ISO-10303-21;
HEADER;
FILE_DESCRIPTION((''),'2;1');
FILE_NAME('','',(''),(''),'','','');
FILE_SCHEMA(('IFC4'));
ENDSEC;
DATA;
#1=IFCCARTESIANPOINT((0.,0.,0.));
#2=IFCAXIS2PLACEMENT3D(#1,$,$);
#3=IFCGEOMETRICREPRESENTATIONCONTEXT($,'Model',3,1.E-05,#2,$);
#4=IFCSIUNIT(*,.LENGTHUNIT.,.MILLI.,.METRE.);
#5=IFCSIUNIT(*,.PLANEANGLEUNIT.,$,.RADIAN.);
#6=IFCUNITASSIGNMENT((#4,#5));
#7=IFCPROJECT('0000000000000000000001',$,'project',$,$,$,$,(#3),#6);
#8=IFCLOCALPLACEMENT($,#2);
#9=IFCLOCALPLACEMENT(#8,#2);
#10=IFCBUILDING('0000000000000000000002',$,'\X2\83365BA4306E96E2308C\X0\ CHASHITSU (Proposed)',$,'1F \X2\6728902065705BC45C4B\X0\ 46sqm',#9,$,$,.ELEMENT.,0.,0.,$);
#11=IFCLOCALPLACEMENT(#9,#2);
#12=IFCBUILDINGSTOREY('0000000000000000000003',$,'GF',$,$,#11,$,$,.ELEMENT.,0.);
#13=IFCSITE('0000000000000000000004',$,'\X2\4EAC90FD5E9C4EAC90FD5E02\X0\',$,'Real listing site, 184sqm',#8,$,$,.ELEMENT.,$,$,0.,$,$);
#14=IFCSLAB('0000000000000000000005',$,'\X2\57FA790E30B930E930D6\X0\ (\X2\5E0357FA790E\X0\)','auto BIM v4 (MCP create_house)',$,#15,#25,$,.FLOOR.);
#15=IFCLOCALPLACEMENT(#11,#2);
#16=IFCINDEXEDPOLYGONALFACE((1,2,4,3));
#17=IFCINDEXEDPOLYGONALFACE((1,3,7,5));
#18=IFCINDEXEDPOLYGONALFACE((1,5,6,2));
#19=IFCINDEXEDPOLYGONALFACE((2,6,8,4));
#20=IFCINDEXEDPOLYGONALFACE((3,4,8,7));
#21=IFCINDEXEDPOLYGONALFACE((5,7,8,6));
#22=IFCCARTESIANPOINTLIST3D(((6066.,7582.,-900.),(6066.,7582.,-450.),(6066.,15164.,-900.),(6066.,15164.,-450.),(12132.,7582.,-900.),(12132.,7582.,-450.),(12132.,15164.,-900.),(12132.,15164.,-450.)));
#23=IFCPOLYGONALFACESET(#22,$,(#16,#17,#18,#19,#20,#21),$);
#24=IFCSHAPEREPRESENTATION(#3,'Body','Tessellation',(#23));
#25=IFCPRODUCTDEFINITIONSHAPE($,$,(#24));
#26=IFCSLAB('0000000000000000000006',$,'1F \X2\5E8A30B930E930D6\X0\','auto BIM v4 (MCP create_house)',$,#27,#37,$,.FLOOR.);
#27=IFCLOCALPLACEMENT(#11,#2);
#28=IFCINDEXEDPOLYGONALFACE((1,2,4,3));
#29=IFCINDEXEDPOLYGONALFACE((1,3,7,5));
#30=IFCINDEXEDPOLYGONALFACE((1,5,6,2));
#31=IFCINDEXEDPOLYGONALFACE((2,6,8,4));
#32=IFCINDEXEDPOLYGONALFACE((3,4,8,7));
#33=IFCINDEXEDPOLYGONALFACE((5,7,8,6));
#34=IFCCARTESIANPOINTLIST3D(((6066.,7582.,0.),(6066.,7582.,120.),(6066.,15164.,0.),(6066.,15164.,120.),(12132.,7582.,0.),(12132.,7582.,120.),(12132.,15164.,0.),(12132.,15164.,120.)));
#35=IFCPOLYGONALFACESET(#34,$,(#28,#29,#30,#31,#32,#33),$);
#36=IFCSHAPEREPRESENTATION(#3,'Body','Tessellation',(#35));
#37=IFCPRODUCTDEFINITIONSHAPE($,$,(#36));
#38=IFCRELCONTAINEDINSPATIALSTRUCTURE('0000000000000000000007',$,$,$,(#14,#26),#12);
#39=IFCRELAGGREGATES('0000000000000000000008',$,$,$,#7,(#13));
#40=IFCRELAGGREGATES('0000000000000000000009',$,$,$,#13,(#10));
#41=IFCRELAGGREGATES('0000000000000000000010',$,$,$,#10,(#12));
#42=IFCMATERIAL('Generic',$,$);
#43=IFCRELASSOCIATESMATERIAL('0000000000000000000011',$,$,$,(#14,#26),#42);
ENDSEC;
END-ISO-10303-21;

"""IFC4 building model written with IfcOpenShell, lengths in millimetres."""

from ifc_helpers import new_model, si_unit, frame, frame_2d, origin, place, context, project, spatial, rectangle, extrude, material, element, save


model = new_model("IFC4")

# Units and contexts
model_context = context("Model", 3, precision=1e-05, world=origin())
ifc_project = project(units=[si_unit("LENGTHUNIT", "METRE", prefix="MILLI"), si_unit("PLANEANGLEUNIT", "RADIAN")], contexts=[model_context])

# Site, building, storey
site_placement = place(None, origin())
site = spatial("IfcSite", under=ifc_project, at=site_placement, Name="京都府京都市", ObjectType="Real listing site, 184sqm", CompositionType="ELEMENT", RefElevation=0.0)
building_placement = place(site_placement, origin())
building = spatial("IfcBuilding", under=site, at=building_placement, Name="茶室の離れ CHASHITSU (Proposed)", ObjectType="1F 木造数寄屋 46sqm", CompositionType="ELEMENT", ElevationOfRefHeight=0.0, ElevationOfTerrain=0.0)
storey_placement = place(building_placement, origin())
storey = spatial("IfcBuildingStorey", under=building, at=storey_placement, Name="GF", CompositionType="ELEMENT", Elevation=0.0)

# Slabs
ifc_material = material(Name="Generic")
slab_1_placement = place(storey_placement, frame((3033.0, 3791.0, -450.0)))
element("IfcSlab", 1, at=slab_1_placement, inside=storey, material=ifc_material, Name="基礎スラブ (布基礎)", Description="auto BIM v4 (MCP create_house)", PredefinedType="FLOOR", context=model_context, shape_type="SweptSolid", body=[
    extrude(rectangle(XDim=6066.0, YDim=7582.0, at=frame_2d((3033.0, 3791.0))), frame((3033.0, 3791.0, -450.0)), (0.0, 0.0, 1.0), 450.0),
])
slab_2_placement = place(storey_placement, frame((3033.0, 3791.0, 0.0)))
element("IfcSlab", 2, at=slab_2_placement, inside=storey, material=ifc_material, Name="1F 床スラブ", Description="auto BIM v4 (MCP create_house)", PredefinedType="FLOOR", context=model_context, shape_type="SweptSolid", body=[
    extrude(rectangle(XDim=6066.0, YDim=7582.0, at=frame_2d((3033.0, 3791.0))), frame((3033.0, 3791.0, 0.0)), (0.0, 0.0, 1.0), 120.0),
])

save(model, "model.ifc")
